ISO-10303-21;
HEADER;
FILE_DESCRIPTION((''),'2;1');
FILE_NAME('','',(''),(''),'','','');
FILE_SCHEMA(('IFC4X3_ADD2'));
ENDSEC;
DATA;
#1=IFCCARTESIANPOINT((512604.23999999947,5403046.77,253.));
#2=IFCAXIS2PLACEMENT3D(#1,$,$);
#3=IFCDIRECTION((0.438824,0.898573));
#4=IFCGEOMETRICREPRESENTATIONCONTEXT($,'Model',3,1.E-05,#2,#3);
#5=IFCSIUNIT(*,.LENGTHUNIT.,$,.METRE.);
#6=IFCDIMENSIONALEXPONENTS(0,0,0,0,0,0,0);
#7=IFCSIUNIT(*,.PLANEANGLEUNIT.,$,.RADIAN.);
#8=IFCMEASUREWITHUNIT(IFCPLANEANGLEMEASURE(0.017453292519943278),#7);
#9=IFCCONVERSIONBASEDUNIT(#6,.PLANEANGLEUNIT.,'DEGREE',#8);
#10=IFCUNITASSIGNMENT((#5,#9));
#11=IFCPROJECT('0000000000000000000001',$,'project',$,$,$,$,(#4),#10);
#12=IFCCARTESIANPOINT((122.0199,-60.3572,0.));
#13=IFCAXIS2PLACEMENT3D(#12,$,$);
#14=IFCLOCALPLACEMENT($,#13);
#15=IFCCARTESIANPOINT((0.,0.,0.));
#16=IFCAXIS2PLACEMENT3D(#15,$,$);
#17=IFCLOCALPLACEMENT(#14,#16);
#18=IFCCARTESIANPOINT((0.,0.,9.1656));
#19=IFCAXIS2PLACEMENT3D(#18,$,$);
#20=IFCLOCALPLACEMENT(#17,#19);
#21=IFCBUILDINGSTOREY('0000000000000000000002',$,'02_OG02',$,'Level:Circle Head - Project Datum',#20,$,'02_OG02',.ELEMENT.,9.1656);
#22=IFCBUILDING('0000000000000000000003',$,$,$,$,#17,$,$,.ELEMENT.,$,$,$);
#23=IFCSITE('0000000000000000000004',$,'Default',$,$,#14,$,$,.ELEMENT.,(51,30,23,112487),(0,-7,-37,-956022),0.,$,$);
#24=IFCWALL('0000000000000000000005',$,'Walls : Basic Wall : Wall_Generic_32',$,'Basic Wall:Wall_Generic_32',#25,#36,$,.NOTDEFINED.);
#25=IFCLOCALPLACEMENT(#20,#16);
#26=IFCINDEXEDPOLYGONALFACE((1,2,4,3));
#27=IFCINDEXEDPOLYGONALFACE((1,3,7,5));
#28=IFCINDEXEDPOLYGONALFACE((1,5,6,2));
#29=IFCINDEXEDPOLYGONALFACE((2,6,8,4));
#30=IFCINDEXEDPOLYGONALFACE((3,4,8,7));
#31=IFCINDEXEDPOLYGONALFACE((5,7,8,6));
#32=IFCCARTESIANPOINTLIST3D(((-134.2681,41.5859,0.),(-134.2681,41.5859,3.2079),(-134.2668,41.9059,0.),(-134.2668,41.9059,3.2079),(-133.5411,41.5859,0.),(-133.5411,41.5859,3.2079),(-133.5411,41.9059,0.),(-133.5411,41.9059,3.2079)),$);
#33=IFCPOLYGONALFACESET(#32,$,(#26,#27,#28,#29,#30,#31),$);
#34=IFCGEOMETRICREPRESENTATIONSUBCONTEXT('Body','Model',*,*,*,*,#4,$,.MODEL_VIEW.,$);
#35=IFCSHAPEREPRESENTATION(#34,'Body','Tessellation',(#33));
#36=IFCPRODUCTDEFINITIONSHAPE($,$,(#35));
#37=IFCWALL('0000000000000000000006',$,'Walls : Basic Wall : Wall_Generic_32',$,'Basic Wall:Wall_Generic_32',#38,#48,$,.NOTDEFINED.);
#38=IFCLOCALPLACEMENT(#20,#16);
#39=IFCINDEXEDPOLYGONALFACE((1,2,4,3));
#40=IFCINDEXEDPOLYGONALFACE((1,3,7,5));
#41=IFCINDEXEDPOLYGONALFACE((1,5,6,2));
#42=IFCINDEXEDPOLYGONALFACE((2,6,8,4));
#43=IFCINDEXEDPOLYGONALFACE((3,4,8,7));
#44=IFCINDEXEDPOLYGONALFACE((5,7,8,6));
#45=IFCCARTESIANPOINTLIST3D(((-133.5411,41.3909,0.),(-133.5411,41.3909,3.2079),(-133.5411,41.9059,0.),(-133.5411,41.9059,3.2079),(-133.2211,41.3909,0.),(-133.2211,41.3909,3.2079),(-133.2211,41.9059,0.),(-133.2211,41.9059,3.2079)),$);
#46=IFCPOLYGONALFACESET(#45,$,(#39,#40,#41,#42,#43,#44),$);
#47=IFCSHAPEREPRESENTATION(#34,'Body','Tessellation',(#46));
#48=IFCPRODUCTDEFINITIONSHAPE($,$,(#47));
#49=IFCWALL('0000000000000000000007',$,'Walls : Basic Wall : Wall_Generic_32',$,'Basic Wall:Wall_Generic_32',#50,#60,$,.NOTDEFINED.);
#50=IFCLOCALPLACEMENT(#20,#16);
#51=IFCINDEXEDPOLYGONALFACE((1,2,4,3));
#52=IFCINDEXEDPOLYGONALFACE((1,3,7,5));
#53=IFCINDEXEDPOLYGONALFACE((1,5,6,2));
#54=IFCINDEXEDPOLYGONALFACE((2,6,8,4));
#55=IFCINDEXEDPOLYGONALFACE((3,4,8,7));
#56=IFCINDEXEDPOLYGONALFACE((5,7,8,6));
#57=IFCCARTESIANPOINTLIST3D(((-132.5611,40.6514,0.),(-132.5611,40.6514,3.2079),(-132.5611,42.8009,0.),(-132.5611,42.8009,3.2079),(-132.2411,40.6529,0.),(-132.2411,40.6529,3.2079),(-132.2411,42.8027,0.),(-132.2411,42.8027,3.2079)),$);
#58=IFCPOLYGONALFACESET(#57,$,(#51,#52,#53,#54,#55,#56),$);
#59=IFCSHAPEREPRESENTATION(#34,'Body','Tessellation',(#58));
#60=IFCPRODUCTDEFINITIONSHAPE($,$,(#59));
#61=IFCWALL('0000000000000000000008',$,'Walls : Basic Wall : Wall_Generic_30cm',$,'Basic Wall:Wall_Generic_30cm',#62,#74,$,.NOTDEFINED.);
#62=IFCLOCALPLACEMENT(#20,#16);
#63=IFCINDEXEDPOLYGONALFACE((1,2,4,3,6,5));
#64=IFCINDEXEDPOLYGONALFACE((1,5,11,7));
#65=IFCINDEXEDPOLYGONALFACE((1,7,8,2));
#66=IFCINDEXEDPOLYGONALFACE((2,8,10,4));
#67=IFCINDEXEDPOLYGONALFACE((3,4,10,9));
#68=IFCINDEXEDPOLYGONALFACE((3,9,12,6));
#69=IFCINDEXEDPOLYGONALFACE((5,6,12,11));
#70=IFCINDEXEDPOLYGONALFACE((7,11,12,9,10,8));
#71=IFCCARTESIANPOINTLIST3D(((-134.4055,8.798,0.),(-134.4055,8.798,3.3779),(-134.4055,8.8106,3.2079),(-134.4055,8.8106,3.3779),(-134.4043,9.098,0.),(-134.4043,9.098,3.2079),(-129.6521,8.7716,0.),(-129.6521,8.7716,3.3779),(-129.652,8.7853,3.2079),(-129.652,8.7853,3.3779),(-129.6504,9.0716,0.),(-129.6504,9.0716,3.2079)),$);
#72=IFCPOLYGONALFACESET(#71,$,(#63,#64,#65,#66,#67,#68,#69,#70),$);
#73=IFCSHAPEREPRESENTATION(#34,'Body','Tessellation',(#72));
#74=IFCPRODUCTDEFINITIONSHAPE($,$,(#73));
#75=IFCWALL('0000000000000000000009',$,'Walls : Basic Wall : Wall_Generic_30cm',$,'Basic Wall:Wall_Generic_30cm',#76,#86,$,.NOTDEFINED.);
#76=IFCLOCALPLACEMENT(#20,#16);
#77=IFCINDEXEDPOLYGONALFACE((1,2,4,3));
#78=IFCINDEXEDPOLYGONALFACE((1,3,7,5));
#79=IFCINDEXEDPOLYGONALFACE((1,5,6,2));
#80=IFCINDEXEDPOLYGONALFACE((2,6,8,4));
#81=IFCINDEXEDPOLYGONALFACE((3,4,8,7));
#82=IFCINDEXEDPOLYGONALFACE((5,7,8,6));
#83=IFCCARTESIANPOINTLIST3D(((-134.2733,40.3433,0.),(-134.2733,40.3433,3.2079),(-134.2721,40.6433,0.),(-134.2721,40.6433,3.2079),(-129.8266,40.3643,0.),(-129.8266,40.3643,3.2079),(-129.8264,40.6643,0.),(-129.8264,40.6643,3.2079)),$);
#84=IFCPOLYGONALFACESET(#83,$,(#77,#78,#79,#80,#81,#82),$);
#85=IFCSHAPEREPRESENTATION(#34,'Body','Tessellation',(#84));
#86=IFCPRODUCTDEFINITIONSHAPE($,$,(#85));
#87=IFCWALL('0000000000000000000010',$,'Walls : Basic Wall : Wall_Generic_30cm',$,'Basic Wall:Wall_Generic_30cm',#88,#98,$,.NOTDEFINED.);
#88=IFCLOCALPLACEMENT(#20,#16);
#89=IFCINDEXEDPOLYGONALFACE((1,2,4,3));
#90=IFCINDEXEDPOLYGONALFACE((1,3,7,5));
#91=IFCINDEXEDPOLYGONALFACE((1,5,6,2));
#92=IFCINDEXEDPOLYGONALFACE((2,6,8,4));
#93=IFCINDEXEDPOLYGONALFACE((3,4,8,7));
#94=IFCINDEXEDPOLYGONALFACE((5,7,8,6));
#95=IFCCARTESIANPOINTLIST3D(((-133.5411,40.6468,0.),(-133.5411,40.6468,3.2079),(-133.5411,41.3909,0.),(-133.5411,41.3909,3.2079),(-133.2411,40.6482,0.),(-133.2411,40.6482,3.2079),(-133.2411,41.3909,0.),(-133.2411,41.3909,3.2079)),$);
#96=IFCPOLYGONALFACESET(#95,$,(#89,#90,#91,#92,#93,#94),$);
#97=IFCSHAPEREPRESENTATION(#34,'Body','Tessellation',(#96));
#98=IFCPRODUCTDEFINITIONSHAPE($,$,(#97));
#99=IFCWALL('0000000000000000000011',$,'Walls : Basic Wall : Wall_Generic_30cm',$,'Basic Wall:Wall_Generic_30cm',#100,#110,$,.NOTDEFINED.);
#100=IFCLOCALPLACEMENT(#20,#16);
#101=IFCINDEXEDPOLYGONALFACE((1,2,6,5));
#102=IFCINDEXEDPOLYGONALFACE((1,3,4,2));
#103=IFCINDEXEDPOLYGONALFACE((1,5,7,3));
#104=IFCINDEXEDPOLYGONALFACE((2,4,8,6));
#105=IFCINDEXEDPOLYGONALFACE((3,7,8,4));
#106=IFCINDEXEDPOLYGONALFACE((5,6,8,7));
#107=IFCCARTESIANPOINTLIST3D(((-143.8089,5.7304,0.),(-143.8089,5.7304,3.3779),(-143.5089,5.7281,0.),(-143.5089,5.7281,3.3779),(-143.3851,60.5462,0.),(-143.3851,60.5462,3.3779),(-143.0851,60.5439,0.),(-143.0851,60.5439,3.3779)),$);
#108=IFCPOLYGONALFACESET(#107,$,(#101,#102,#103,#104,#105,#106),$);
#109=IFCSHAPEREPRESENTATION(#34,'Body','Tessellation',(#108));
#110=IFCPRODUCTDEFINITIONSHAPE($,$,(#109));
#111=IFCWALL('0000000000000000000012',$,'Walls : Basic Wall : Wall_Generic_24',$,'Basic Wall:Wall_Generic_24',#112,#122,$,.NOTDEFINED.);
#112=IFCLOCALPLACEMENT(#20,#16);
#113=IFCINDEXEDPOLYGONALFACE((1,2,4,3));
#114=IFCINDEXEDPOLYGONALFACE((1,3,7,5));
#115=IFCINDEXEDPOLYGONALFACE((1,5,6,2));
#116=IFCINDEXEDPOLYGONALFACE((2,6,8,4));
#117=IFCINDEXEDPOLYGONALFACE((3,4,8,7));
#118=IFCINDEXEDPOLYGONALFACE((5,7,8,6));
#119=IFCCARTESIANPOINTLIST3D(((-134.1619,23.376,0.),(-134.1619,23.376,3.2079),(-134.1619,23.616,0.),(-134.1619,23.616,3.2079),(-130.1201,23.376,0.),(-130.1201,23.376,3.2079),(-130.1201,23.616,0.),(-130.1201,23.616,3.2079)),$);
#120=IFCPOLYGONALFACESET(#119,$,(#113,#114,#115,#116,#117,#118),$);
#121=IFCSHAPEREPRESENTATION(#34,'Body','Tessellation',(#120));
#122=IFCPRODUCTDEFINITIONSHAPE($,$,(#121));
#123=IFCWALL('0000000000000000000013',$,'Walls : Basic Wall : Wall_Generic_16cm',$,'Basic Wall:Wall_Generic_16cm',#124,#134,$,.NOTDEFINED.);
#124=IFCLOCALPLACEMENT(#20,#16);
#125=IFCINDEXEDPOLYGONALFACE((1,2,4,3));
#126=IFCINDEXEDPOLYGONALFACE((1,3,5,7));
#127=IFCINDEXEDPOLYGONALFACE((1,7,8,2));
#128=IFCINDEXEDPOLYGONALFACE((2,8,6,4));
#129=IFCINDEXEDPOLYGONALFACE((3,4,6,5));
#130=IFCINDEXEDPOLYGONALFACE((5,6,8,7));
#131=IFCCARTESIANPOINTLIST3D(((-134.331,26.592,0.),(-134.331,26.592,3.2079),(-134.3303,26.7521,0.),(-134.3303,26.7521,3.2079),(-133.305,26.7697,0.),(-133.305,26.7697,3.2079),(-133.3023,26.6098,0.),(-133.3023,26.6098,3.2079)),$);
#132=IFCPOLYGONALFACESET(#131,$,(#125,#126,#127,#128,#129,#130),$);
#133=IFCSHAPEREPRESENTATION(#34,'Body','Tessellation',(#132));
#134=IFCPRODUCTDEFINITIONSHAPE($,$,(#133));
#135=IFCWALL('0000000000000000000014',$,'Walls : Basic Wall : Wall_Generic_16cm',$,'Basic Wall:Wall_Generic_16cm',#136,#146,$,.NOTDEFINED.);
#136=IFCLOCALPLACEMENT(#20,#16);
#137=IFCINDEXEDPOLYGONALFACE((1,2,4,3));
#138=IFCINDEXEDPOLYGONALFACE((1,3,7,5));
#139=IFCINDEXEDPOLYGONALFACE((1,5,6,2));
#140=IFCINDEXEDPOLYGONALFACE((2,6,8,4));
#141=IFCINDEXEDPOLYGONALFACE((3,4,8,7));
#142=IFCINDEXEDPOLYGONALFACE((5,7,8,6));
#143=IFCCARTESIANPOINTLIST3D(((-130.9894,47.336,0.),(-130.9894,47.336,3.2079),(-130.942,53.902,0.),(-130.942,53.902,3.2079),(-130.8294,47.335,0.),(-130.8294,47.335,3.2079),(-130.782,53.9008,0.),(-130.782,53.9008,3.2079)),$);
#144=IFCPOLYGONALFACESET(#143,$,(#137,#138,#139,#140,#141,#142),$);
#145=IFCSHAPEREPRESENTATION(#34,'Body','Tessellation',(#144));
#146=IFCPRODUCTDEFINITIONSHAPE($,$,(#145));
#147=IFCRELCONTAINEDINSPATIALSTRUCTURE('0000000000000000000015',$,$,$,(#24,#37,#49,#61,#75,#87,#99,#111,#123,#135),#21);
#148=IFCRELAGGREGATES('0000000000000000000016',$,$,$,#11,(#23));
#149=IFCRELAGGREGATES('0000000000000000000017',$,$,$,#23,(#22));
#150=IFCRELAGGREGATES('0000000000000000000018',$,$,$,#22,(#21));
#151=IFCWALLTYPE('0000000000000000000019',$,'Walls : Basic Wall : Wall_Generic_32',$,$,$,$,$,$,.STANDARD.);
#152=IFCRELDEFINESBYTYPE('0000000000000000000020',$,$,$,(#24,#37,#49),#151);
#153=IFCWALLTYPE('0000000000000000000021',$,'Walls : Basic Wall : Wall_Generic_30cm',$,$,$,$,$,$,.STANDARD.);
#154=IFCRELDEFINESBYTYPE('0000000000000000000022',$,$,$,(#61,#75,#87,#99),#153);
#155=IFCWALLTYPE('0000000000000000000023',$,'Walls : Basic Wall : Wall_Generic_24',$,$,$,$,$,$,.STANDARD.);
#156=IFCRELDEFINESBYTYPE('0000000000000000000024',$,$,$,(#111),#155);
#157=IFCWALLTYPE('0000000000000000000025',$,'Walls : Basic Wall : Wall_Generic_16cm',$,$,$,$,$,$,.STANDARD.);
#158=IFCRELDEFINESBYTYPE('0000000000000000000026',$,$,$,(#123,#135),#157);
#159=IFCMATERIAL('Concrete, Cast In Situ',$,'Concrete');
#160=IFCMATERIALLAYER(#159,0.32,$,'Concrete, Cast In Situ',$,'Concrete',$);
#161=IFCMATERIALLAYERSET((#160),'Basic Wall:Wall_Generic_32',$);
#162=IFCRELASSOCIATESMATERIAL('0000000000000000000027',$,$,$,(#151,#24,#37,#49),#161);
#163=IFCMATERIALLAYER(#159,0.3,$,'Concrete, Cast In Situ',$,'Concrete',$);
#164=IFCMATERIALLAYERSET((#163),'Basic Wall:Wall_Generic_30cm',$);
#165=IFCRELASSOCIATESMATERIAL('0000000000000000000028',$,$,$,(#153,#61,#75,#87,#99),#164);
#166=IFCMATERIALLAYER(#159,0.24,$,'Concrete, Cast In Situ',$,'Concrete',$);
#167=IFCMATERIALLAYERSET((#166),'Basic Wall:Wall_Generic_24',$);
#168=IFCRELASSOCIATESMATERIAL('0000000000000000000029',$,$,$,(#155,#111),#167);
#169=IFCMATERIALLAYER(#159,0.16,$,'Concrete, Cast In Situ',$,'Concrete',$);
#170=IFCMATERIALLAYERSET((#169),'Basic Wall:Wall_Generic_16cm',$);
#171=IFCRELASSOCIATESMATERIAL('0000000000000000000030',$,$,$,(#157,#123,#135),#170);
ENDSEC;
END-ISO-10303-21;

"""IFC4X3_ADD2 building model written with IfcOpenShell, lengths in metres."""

from ifc_helpers import new_model, entity, si_unit, converted_unit, direction, frame, frame_2d, origin, place, context, subcontext, project, spatial, polyline, rectangle, outline, extrude, clip, halfspace, bounded_halfspace, material, layer, layer_set, type_object, element, save


model = new_model("IFC4X3_ADD2")

# Units and contexts
model_context = context("Model", 3, precision=1e-05, world=frame((512604.23999999947, 5403046.77, 253.0)), true_north=direction((0.438824, 0.898573)))
body_context = subcontext(model_context, "Body", "Model", "MODEL_VIEW")
ifc_project = project(units=[si_unit("LENGTHUNIT", "METRE"), converted_unit("PLANEANGLEUNIT", "DEGREE", entity("IfcPlaneAngleMeasure", 0.017453292519943278), si_unit("PLANEANGLEUNIT", "RADIAN"), dimensions=[0, 0, 0, 0, 0, 0, 0])], contexts=[model_context])

# Site, building, storey
site_placement = place(None, frame((122.0199, -60.3572, 0.0)))
site = spatial("IfcSite", under=ifc_project, at=site_placement, Name="Default", CompositionType="ELEMENT", RefLatitude=(51, 30, 23, 112487), RefLongitude=(0, -7, -37, -956022), RefElevation=0.0)
building_placement = place(site_placement, origin())
building = spatial("IfcBuilding", under=site, at=building_placement, CompositionType="ELEMENT")
storey_placement = place(building_placement, frame((0.0, 0.0, 9.1656)))
storey = spatial("IfcBuildingStorey", under=building, at=storey_placement, Name="02_OG02", ObjectType="Level:Circle Head - Project Datum", LongName="02_OG02", CompositionType="ELEMENT", Elevation=9.1656)

# Shared definitions
ifc_material_1 = material(Name="Concrete, Cast In Situ", Category="Concrete")
ifc_layer_1 = layer(ifc_material_1, 0.32, Name="Concrete, Cast In Situ", Category="Concrete")
ifc_layer_set_1 = layer_set([ifc_layer_1], Name="Basic Wall:Wall_Generic_32")
wall_type_1 = type_object("IfcWallType", Name="Walls : Basic Wall : Wall_Generic_32", PredefinedType="STANDARD", material=ifc_layer_set_1)

# Walls
wall_1_placement = place(storey_placement, frame((-134.2681, 41.7459, 0.0)))
element("IfcWall", 1, at=wall_1_placement, inside=storey, type_object=wall_type_1, material=ifc_layer_set_1, Name="Walls : Basic Wall : Wall_Generic_32", ObjectType="Basic Wall:Wall_Generic_32", PredefinedType="NOTDEFINED", context=body_context, shape_type="Clipping", body=[
    clip(extrude(outline(polyline([(0.727, -0.16), (0.727, 0.16), (0.0013, 0.16), (0.0, -0.16), (0.727, -0.16)])), origin(), (0.0, 0.0, 1.0), 3.2079), bounded_halfspace(frame((0.0, -0.16, 3.2079), z_axis=(0.0, 0.0, -1.0), x_axis=(-0.000002, -1.0, 0.0)), True, frame((0.0, -0.16, 3.2079)), polyline([(0.0, 0.0), (0.727, 0.0), (0.727, 0.32), (0.0013, 0.32), (0.0, 0.0)]))),
])
wall_2_placement = place(storey_placement, frame((-133.3811, 41.9059, 0.0), z_axis=(0.0, 0.0, 1.0), x_axis=(0.0, -1.0, 0.0)))
element("IfcWall", 2, at=wall_2_placement, inside=storey, type_object=wall_type_1, material=ifc_layer_set_1, Name="Walls : Basic Wall : Wall_Generic_32", ObjectType="Basic Wall:Wall_Generic_32", PredefinedType="NOTDEFINED", context=body_context, shape_type="Clipping", body=[
    clip(extrude(rectangle(XDim=0.515, YDim=0.32, at=frame_2d((0.2575, 0.0), x_axis=(-1.0, 0.0))), origin(), (0.0, 0.0, 1.0), 3.2079), bounded_halfspace(frame((0.0, -0.16, 3.2079), z_axis=(0.0, 0.0, -1.0), x_axis=(1.0, -0.000002, 0.0)), True, frame((0.0, -0.16, 3.2079)), polyline([(0.0, 0.0), (0.32, 0.0), (0.515, 0.0), (0.515, 0.3), (0.515, 0.32), (0.355, 0.32), (0.0, 0.32), (0.0, 0.0)]))),
])
wall_3_placement = place(storey_placement, frame((-132.4011, 40.6514, 0.0), z_axis=(0.0, 0.0, 1.0), x_axis=(0.0, 1.0, 0.0)))
element("IfcWall", 3, at=wall_3_placement, inside=storey, type_object=wall_type_1, material=ifc_layer_set_1, Name="Walls : Basic Wall : Wall_Generic_32", ObjectType="Basic Wall:Wall_Generic_32", PredefinedType="NOTDEFINED", context=body_context, shape_type="Clipping", body=[
    clip(extrude(outline(polyline([(2.1513, -0.16), (2.1495, 0.16), (0.8995, 0.16), (0.5795, 0.16), (0.0, 0.16), (0.0015, -0.16), (2.1513, -0.16)])), origin(), (0.0, 0.0, 1.0), 3.2079), bounded_halfspace(frame((0.0015, -0.16, 3.2079), z_axis=(0.0, 0.0, -1.0), x_axis=(-1.0, 0.000002, 0.0)), True, frame((0.0015, -0.16, 3.2079)), polyline([(0.0, 0.0), (2.1498, 0.0), (2.148, 0.32), (0.898, 0.32), (0.578, 0.32), (-0.0015, 0.32), (0.0, 0.0)]))),
])
ifc_layer_2 = layer(ifc_material_1, 0.3, Name="Concrete, Cast In Situ", Category="Concrete")
ifc_layer_set_2 = layer_set([ifc_layer_2], Name="Basic Wall:Wall_Generic_30cm")
wall_type_2 = type_object("IfcWallType", Name="Walls : Basic Wall : Wall_Generic_30cm", PredefinedType="STANDARD", material=ifc_layer_set_2)
wall_4_placement = place(storey_placement, frame((-134.4051, 8.948, 0.0), z_axis=(0.0, 0.0, 1.0), x_axis=(0.999985, -0.00555, 0.0)))
element("IfcWall", 4, at=wall_4_placement, inside=storey, type_object=wall_type_2, material=ifc_layer_set_2, Name="Walls : Basic Wall : Wall_Generic_30cm", ObjectType="Basic Wall:Wall_Generic_30cm", PredefinedType="NOTDEFINED", context=body_context, shape_type="Clipping", body=[
    clip(extrude(outline(polyline([(4.754, -0.15), (4.754, 0.15), (4.454, 0.15), (0.0, 0.15), (0.0004, -0.15), (4.754, -0.15)])), origin(), (0.0, 0.0, 1.0), 3.3779), bounded_halfspace(frame((4.754, -0.1362, 3.2079), z_axis=(0.0, 0.0, -1.0), x_axis=(0.005549, -0.999985, 0.0)), True, frame((4.754, -0.1362, 3.2079)), polyline([(0.0, 0.0), (0.0, 0.2862), (-0.3, 0.2862), (-4.754, 0.2862), (-4.7536, -0.0012), (-0.3904, -0.0001), (0.0, 0.0)]))),
])
wall_5_placement = place(storey_placement, frame((-134.274, 40.4933, 0.0), z_axis=(0.0, 0.0, 1.0), x_axis=(0.999989, 0.004708, 0.0)))
element("IfcWall", 5, at=wall_5_placement, inside=storey, type_object=wall_type_2, material=ifc_layer_set_2, Name="Walls : Basic Wall : Wall_Generic_30cm", ObjectType="Basic Wall:Wall_Generic_30cm", PredefinedType="NOTDEFINED", context=body_context, shape_type="Clipping", body=[
    clip(extrude(outline(polyline([(4.4468, -0.15), (4.4484, 0.15), (2.0337, 0.15), (1.7136, 0.15), (1.0336, 0.15), (0.7336, 0.15), (0.0027, 0.15), (0.0, -0.15), (4.4468, -0.15)])), origin(), (0.0, 0.0, 1.0), 3.2079), bounded_halfspace(frame((0.0, -0.15, 3.2079), z_axis=(0.0, 0.0, -1.0), x_axis=(-0.00471, -0.999989, 0.0)), True, frame((0.0, -0.15, 3.2079)), polyline([(0.0, 0.0), (4.4468, 0.0), (4.4484, 0.3), (2.0337, 0.3), (1.7136, 0.3), (1.0336, 0.3), (0.7336, 0.3), (0.0027, 0.3), (0.0, 0.0)]))),
])
wall_6_placement = place(storey_placement, frame((-133.3911, 41.3909, 0.0), z_axis=(0.0, 0.0, 1.0), x_axis=(0.0, -1.0, 0.0)))
element("IfcWall", 6, at=wall_6_placement, inside=storey, type_object=wall_type_2, material=ifc_layer_set_2, Name="Walls : Basic Wall : Wall_Generic_30cm", ObjectType="Basic Wall:Wall_Generic_30cm", PredefinedType="NOTDEFINED", context=body_context, shape_type="Clipping", body=[
    clip(extrude(outline(polyline([(0.7441, -0.15), (0.7427, 0.15), (0.16, 0.15), (0.0, 0.15), (0.0, -0.15), (0.7441, -0.15)])), origin(), (0.0, 0.0, 1.0), 3.2079), bounded_halfspace(frame((0.0, -0.15, 3.2079), z_axis=(0.0, 0.0, -1.0), x_axis=(1.0, -0.000002, 0.0)), True, frame((0.0, -0.15, 3.2079)), polyline([(0.0, 0.0), (0.7441, 0.0), (0.7427, 0.3), (0.16, 0.3), (0.0, 0.3), (0.0, 0.0)]))),
])
wall_7_placement = place(storey_placement, frame((-143.2351, 60.5451, 0.0), z_axis=(0.0, 0.0, 1.0), x_axis=(-0.007732, -0.99997, 0.0)))
element("IfcWall", 7, at=wall_7_placement, inside=storey, type_object=wall_type_2, material=ifc_layer_set_2, Name="Walls : Basic Wall : Wall_Generic_30cm", ObjectType="Basic Wall:Wall_Generic_30cm", PredefinedType="NOTDEFINED", context=body_context, shape_type="Clipping", body=[
    clip(extrude(rectangle(XDim=54.8174, YDim=0.3, at=frame_2d((27.4087, 0.0), x_axis=(-1.0, 0.0))), origin(), (0.0, 0.0, 1.0), 3.3779), halfspace(frame((0.0, 0.0, -9.1656)), True)),
])
ifc_layer_3 = layer(ifc_material_1, 0.24, Name="Concrete, Cast In Situ", Category="Concrete")
ifc_layer_set_3 = layer_set([ifc_layer_3], Name="Basic Wall:Wall_Generic_24")
wall_type_3 = type_object("IfcWallType", Name="Walls : Basic Wall : Wall_Generic_24", PredefinedType="STANDARD", material=ifc_layer_set_3)
wall_8_placement = place(storey_placement, frame((-134.1619, 23.496, 0.0)))
element("IfcWall", 8, at=wall_8_placement, inside=storey, type_object=wall_type_3, material=ifc_layer_set_3, Name="Walls : Basic Wall : Wall_Generic_24", ObjectType="Basic Wall:Wall_Generic_24", PredefinedType="NOTDEFINED", context=body_context, shape_type="Clipping", body=[
    clip(extrude(rectangle(XDim=4.0417, YDim=0.24, at=frame_2d((2.0209, 0.0), x_axis=(-1.0, 0.0))), origin(), (0.0, 0.0, 1.0), 3.2079), bounded_halfspace(frame((0.0, -0.12, 3.2079), z_axis=(0.0, 0.0, -1.0), x_axis=(-0.000002, -1.0, 0.0)), True, frame((0.0, -0.12, 3.2079)), polyline([(0.0, 0.0), (4.0417, 0.0), (4.0417, 0.24), (0.0, 0.24), (0.0, 0.1816), (0.0, 0.0)]))),
])
ifc_layer_4 = layer(ifc_material_1, 0.16, Name="Concrete, Cast In Situ", Category="Concrete")
ifc_layer_set_4 = layer_set([ifc_layer_4], Name="Basic Wall:Wall_Generic_16cm")
wall_type_4 = type_object("IfcWallType", Name="Walls : Basic Wall : Wall_Generic_16cm", PredefinedType="STANDARD", material=ifc_layer_set_4)
wall_9_placement = place(storey_placement, frame((-134.3323, 26.672, 0.0), z_axis=(0.0, 0.0, 1.0), x_axis=(0.999851, 0.017233, 0.0)))
element("IfcWall", 9, at=wall_9_placement, inside=storey, type_object=wall_type_4, material=ifc_layer_set_4, Name="Walls : Basic Wall : Wall_Generic_16cm", ObjectType="Basic Wall:Wall_Generic_16cm", PredefinedType="NOTDEFINED", context=body_context, shape_type="Clipping", body=[
    clip(extrude(outline(polyline([(1.0289, -0.08), (1.0289, 0.08), (0.0034, 0.08), (0.0, -0.08), (1.0289, -0.08)])), origin(), (0.0, 0.0, 1.0), 3.2079), bounded_halfspace(frame((0.0, -0.08, 3.2079), z_axis=(0.0, 0.0, -1.0), x_axis=(-0.017235, -0.999851, 0.0)), True, frame((0.0, -0.08, 3.2079)), polyline([(0.0, 0.0), (1.0289, 0.0), (1.0289, 0.16), (0.0034, 0.16), (0.0, 0.0)]))),
])
wall_10_placement = place(storey_placement, frame((-130.9094, 47.3354, 0.0), z_axis=(0.0, 0.0, 1.0), x_axis=(0.00723, 0.999974, 0.0)))
element("IfcWall", 10, at=wall_10_placement, inside=storey, type_object=wall_type_4, material=ifc_layer_set_4, Name="Walls : Basic Wall : Wall_Generic_16cm", ObjectType="Basic Wall:Wall_Generic_16cm", PredefinedType="NOTDEFINED", context=body_context, shape_type="Clipping", body=[
    clip(extrude(outline(polyline([(6.5661, -0.08), (6.5661, 0.08), (0.1, 0.08), (0.0, 0.08), (0.0002, -0.08), (6.5661, -0.08)])), origin(), (0.0, 0.0, 1.0), 3.2079), bounded_halfspace(frame((0.0002, -0.08, 3.2079), z_axis=(0.0, 0.0, -1.0), x_axis=(-0.999974, -0.007229, 0.0)), True, frame((0.0002, -0.08, 3.2079)), polyline([(0.0, 0.0), (6.566, 0.0), (6.566, 0.16), (0.0998, 0.16), (-0.0002, 0.16), (0.0, 0.0)]))),
])

save(model, "model.ifc")
